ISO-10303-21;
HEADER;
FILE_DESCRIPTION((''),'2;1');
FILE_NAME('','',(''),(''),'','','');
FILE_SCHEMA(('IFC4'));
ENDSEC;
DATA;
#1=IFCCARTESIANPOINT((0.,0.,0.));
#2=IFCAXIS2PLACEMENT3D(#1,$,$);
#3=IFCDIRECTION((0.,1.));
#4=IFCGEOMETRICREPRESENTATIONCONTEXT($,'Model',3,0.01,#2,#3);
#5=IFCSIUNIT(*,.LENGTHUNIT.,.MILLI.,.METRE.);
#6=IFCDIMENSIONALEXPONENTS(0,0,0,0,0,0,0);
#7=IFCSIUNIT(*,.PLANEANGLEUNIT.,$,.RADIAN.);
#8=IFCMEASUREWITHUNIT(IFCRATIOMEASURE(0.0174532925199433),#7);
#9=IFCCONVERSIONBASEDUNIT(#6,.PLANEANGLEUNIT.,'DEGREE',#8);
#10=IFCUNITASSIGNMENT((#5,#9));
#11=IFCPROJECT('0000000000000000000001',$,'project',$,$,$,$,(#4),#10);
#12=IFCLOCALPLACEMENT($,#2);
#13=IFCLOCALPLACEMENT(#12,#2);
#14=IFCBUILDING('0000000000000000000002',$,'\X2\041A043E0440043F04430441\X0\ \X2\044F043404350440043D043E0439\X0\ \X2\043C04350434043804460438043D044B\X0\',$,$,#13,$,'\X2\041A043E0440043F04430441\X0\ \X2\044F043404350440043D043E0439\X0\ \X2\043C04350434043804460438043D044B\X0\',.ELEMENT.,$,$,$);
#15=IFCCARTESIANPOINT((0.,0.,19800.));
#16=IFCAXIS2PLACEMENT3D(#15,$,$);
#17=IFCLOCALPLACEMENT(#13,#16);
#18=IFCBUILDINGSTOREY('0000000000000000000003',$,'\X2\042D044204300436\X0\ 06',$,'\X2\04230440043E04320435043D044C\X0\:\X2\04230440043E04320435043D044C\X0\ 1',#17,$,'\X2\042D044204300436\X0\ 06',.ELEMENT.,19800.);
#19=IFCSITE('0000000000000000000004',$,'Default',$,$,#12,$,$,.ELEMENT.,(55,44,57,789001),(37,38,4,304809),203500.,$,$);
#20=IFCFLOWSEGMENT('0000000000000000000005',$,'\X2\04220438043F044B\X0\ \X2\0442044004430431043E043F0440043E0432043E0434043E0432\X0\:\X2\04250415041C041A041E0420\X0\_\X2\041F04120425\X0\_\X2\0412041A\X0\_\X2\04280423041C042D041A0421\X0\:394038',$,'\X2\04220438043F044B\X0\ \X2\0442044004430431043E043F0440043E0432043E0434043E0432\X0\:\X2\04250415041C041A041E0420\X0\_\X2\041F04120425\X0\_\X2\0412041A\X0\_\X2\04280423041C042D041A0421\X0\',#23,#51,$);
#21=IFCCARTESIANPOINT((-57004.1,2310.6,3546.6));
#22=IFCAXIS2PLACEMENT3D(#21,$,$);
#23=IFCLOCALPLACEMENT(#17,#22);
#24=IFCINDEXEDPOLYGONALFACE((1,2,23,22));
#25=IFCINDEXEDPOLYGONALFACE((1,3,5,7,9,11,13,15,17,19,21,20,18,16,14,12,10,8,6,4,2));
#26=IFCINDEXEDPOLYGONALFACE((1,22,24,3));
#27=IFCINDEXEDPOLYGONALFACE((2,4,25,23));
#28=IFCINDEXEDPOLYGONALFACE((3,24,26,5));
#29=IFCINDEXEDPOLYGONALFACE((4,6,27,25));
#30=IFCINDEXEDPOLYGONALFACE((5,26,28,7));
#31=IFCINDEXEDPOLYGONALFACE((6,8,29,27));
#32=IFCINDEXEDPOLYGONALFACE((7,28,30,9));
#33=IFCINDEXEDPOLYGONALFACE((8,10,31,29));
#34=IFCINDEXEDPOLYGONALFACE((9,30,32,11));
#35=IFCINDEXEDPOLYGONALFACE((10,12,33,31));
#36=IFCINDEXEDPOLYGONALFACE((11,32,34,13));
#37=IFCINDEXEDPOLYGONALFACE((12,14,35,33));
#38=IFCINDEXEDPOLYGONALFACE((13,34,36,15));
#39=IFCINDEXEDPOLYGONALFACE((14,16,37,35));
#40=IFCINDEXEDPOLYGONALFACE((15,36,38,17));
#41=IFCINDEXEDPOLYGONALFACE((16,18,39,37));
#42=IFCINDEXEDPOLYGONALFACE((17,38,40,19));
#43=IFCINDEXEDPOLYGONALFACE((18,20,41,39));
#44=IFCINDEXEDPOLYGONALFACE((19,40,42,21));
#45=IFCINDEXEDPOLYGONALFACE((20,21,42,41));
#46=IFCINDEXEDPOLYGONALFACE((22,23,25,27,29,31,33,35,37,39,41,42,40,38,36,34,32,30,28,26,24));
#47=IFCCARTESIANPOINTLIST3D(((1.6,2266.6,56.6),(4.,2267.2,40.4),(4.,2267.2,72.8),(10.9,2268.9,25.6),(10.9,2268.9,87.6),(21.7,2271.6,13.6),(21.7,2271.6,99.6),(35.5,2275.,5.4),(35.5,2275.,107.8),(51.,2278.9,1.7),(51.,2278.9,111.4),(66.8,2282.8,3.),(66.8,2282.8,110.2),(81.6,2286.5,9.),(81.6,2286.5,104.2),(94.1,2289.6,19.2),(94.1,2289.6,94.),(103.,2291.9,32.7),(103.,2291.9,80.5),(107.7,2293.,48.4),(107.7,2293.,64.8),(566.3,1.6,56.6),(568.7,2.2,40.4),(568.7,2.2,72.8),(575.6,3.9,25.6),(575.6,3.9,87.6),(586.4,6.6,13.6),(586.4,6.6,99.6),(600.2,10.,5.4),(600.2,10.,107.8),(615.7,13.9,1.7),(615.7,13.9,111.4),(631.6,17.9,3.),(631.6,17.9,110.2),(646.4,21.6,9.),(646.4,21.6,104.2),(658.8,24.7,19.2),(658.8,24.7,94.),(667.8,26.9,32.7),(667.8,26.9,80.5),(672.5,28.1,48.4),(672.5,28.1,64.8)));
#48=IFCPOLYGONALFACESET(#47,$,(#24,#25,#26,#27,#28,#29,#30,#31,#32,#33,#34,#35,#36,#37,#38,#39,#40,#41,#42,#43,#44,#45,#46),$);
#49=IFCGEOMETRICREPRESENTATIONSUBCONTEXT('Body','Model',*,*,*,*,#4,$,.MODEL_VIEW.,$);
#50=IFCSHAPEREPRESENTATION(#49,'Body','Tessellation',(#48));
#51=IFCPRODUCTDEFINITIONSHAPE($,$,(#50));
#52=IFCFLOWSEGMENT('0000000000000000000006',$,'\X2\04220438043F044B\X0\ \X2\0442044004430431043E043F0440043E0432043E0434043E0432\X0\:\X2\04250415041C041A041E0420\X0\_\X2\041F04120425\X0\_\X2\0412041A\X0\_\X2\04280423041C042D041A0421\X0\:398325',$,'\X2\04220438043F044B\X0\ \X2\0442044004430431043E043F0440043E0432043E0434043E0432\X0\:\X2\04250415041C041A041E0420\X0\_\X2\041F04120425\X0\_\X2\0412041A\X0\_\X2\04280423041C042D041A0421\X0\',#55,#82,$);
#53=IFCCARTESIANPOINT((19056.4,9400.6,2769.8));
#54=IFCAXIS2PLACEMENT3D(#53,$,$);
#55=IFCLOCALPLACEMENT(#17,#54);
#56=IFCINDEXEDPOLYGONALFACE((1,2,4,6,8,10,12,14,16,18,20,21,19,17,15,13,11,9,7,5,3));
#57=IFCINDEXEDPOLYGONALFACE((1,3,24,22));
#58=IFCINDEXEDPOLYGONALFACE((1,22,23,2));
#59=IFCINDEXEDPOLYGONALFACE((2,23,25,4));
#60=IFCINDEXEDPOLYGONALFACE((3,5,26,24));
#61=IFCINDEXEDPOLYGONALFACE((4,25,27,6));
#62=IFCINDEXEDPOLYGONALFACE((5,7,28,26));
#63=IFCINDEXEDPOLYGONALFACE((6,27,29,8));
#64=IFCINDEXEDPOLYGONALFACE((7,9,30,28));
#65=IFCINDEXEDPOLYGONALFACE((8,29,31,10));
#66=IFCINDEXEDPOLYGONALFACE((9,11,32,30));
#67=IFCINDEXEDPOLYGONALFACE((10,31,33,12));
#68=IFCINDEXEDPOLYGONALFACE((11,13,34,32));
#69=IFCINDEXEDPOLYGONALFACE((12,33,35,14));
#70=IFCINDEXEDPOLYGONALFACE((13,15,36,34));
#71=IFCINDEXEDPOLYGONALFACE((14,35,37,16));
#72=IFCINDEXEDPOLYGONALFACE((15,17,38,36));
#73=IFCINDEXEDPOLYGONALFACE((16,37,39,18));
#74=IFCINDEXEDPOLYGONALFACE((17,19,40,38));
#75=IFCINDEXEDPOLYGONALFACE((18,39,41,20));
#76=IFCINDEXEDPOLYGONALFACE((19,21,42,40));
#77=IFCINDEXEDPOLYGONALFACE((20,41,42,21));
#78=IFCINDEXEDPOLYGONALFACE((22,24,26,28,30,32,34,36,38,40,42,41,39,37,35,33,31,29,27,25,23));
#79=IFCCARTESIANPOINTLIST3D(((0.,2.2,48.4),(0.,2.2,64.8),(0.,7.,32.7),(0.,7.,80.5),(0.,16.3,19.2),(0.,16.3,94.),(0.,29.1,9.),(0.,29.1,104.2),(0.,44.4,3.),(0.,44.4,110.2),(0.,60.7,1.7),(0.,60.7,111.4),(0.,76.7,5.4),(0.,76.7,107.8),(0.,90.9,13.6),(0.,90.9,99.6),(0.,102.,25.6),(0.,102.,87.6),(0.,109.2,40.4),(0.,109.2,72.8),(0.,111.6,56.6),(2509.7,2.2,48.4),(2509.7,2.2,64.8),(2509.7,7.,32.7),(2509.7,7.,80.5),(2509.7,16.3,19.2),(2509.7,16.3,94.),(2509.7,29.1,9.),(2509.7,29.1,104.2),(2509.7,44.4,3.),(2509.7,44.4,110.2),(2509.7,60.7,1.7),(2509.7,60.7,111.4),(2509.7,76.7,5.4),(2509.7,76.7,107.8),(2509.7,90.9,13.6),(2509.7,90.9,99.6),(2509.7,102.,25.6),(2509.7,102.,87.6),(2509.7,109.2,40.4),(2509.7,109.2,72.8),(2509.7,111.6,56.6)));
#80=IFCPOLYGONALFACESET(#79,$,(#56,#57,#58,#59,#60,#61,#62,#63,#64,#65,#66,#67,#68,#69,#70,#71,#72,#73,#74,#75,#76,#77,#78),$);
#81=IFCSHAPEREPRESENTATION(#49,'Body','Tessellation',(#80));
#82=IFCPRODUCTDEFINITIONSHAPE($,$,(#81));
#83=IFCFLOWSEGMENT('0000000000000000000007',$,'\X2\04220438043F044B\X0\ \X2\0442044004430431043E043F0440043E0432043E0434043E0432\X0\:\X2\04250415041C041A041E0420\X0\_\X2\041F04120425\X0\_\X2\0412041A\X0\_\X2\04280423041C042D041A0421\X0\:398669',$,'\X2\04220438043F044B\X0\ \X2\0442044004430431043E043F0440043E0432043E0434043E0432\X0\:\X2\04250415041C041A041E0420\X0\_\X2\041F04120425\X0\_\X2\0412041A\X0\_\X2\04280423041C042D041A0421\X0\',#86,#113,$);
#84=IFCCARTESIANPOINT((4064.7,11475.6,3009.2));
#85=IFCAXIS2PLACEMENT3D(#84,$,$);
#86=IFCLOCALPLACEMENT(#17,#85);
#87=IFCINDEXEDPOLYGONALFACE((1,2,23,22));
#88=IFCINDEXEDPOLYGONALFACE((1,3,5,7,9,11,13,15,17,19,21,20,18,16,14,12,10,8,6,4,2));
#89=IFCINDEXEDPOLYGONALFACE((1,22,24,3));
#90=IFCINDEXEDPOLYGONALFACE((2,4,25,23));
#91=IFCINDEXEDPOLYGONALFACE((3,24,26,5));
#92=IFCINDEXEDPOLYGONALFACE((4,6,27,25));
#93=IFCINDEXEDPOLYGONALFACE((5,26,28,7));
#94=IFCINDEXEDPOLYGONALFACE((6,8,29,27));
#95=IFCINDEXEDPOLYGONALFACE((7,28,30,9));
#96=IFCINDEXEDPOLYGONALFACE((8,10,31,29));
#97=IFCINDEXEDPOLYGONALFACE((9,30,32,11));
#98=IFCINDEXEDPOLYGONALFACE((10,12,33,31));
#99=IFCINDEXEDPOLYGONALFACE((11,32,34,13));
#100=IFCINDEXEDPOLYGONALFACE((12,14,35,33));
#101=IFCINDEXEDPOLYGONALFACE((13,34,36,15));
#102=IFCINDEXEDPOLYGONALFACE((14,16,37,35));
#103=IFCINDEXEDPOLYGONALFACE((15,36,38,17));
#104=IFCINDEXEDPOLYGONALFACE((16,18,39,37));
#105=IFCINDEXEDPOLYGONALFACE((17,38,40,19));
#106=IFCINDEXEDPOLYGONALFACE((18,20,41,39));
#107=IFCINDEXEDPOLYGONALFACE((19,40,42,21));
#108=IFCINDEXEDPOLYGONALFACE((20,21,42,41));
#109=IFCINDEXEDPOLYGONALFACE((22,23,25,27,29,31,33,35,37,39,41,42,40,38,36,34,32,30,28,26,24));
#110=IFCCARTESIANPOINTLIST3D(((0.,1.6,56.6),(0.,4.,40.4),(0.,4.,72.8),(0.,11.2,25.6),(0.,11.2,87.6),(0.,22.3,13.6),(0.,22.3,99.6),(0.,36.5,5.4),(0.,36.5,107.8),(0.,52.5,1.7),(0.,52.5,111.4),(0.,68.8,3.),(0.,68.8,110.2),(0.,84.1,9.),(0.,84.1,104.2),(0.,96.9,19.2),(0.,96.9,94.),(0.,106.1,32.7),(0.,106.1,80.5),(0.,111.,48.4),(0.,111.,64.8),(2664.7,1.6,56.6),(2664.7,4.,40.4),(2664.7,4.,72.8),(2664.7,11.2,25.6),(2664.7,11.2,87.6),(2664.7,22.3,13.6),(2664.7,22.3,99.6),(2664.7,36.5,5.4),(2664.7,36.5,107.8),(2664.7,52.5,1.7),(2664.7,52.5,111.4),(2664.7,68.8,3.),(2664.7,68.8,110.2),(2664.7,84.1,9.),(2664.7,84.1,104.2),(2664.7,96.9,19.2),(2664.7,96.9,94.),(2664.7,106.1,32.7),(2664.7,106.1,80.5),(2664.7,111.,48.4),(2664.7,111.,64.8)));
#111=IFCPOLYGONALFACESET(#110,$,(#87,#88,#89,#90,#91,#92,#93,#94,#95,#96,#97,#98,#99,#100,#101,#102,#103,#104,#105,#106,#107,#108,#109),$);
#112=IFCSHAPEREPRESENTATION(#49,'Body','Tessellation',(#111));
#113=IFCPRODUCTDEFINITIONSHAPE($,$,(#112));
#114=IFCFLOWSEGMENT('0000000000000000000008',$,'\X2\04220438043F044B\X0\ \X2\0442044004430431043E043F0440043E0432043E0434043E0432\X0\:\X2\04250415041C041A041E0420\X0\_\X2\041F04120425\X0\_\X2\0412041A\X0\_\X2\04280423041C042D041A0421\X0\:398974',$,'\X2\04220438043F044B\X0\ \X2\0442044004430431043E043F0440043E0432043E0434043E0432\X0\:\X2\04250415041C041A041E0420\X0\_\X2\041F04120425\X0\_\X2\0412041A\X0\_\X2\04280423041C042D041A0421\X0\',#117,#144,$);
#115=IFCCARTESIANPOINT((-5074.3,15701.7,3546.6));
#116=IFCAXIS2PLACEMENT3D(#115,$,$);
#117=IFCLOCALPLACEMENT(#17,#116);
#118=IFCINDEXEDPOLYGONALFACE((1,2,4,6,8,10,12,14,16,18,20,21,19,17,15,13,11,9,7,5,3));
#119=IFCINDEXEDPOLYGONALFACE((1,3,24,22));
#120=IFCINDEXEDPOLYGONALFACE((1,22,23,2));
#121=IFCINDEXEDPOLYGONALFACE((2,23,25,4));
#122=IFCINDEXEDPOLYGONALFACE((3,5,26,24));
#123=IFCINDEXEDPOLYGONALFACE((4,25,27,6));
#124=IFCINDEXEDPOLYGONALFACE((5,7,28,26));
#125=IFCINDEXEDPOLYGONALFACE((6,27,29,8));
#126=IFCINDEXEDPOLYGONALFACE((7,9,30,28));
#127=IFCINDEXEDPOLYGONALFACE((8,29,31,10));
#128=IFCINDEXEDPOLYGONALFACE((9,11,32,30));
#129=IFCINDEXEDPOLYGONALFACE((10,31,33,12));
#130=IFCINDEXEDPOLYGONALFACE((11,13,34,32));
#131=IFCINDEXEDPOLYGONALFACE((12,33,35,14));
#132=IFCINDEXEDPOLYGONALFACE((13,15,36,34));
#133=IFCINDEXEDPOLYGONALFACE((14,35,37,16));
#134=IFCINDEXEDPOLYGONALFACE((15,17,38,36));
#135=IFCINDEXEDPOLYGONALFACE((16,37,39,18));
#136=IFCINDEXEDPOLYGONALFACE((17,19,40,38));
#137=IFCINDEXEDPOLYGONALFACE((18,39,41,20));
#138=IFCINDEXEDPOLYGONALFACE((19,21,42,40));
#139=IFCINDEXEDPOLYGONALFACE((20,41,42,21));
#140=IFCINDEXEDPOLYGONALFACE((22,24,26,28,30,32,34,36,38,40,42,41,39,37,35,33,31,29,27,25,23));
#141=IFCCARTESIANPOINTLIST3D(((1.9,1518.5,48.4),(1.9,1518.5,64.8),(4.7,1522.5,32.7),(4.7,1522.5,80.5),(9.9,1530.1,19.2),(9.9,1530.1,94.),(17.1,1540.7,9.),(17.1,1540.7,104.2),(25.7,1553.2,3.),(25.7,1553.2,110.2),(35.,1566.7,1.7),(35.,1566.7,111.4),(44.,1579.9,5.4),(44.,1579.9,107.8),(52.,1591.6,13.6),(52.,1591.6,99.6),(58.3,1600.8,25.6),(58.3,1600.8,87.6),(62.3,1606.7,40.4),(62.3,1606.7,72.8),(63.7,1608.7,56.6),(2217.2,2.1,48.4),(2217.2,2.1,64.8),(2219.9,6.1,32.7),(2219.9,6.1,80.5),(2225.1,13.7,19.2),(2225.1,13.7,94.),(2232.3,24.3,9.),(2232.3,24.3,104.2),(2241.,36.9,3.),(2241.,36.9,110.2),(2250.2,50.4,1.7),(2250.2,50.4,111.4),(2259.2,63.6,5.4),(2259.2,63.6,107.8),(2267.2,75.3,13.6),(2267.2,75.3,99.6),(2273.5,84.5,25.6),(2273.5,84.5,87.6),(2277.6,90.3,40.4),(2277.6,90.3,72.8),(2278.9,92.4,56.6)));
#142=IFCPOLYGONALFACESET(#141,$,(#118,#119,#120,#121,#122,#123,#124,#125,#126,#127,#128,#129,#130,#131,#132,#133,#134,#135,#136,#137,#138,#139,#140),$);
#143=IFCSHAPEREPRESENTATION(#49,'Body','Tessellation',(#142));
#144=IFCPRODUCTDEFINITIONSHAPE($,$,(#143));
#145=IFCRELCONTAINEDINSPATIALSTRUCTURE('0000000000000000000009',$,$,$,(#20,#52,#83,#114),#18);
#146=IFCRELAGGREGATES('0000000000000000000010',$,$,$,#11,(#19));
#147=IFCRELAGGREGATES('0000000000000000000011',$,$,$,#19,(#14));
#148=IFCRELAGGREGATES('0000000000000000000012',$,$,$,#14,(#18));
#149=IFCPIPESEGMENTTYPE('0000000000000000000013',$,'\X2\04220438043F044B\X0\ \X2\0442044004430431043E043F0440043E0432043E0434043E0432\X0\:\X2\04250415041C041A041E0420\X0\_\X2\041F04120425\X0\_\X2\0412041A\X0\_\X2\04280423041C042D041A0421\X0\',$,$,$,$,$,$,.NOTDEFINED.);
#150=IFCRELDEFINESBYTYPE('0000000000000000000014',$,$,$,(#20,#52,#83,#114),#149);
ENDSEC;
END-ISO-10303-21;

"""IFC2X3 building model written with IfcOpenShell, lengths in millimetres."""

from ifc_helpers import new_model, entity, si_unit, converted_unit, direction, frame, frame_2d, origin, origin_2d_with_axis, place, context, subcontext, project, spatial, circle, extrude, type_object, element, save


model = new_model("IFC2X3")

# Units and contexts
model_context = context("Model", 3, precision=0.01, world=origin(), true_north=direction((0.0, 1.0)))
body_context = subcontext(model_context, "Body", "Model", "MODEL_VIEW")
ifc_project = project(units=[si_unit("LENGTHUNIT", "METRE", prefix="MILLI"), converted_unit("PLANEANGLEUNIT", "DEGREE", entity("IfcRatioMeasure", 0.0174532925199433), si_unit("PLANEANGLEUNIT", "RADIAN"), dimensions=[0, 0, 0, 0, 0, 0, 0])], contexts=[model_context])

# Site, building, storey
site_placement = place(None, frame((0.0, 0.0, 0.0)))
site = spatial("IfcSite", under=ifc_project, at=site_placement, Name="Default", CompositionType="ELEMENT", RefLatitude=(55, 44, 57, 789001), RefLongitude=(37, 38, 4, 304809), RefElevation=203500.0)
building_placement = place(site_placement, origin())
building = spatial("IfcBuilding", under=site, at=building_placement, Name="Корпус ядерной медицины", LongName="Корпус ядерной медицины", CompositionType="ELEMENT")
storey_placement = place(building_placement, frame((0.0, 0.0, 19800.0)))
storey = spatial("IfcBuildingStorey", under=building, at=storey_placement, Name="Этаж 06", ObjectType="Уровень:Уровень 1", LongName="Этаж 06", CompositionType="ELEMENT", Elevation=19800.0)

# Flow segments
pipe_segment_type = type_object("IfcPipeSegmentType", Name="Типы трубопроводов:ХЕМКОР_ПВХ_ВК_ШУМЭКС", PredefinedType="NOTDEFINED")
flow_segment_1_placement = place(storey_placement, frame((-57004.1, 2310.6, 3546.6)))
element("IfcFlowSegment", 1, at=flow_segment_1_placement, inside=storey, type_object=pipe_segment_type, Name="Типы трубопроводов:ХЕМКОР_ПВХ_ВК_ШУМЭКС:394038", ObjectType="Типы трубопроводов:ХЕМКОР_ПВХ_ВК_ШУМЭКС", context=body_context, shape_type="SweptSolid", body=[
    extrude(circle(Radius=55.0, at=frame_2d((0.0, 0.0), x_axis=(1.0, 0.0))), frame((619.7, 14.9, 56.6), z_axis=(-0.241922, 0.970296, 0.0), x_axis=(-0.970296, -0.241922, 0.0)), (0.0, 0.0, 1.0), 2334.3),
])
flow_segment_2_placement = place(storey_placement, frame((19056.4, 9400.6, 2769.8)))
element("IfcFlowSegment", 2, at=flow_segment_2_placement, inside=storey, type_object=pipe_segment_type, Name="Типы трубопроводов:ХЕМКОР_ПВХ_ВК_ШУМЭКС:398325", ObjectType="Типы трубопроводов:ХЕМКОР_ПВХ_ВК_ШУМЭКС", context=body_context, shape_type="SweptSolid", body=[
    extrude(circle(Radius=55.0, at=frame_2d((0.0, 0.0), x_axis=(1.0, 0.0))), frame((0.0, 56.6, 56.6), z_axis=(1.0, 0.0, 0.0), x_axis=(0.0, 1.0, 0.0)), (0.0, 0.0, 1.0), 2509.7),
])
flow_segment_3_placement = place(storey_placement, frame((4064.7, 11475.6, 3009.2)))
element("IfcFlowSegment", 3, at=flow_segment_3_placement, inside=storey, type_object=pipe_segment_type, Name="Типы трубопроводов:ХЕМКОР_ПВХ_ВК_ШУМЭКС:398669", ObjectType="Типы трубопроводов:ХЕМКОР_ПВХ_ВК_ШУМЭКС", context=body_context, shape_type="SweptSolid", body=[
    extrude(circle(Radius=55.0, at=origin_2d_with_axis()), frame((0.0, 56.6, 56.6), z_axis=(1.0, 0.0, 0.0), x_axis=(0.0, -1.0, 0.0)), (0.0, 0.0, 1.0), 2664.7),
])
flow_segment_4_placement = place(storey_placement, frame((-5074.3, 15701.7, 3546.6)))
element("IfcFlowSegment", 4, at=flow_segment_4_placement, inside=storey, type_object=pipe_segment_type, Name="Типы трубопроводов:ХЕМКОР_ПВХ_ВК_ШУМЭКС:398974", ObjectType="Типы трубопроводов:ХЕМКОР_ПВХ_ВК_ШУМЭКС", context=body_context, shape_type="SweptSolid", body=[
    extrude(circle(Radius=55.0, at=origin_2d_with_axis()), frame((2247.9, 47.0, 56.6), z_axis=(-0.825187, 0.564859, 0.0), x_axis=(0.564859, 0.825187, 0.0)), (0.0, 0.0, 1.0), 2684.5),
])

save(model, "model.ifc")
